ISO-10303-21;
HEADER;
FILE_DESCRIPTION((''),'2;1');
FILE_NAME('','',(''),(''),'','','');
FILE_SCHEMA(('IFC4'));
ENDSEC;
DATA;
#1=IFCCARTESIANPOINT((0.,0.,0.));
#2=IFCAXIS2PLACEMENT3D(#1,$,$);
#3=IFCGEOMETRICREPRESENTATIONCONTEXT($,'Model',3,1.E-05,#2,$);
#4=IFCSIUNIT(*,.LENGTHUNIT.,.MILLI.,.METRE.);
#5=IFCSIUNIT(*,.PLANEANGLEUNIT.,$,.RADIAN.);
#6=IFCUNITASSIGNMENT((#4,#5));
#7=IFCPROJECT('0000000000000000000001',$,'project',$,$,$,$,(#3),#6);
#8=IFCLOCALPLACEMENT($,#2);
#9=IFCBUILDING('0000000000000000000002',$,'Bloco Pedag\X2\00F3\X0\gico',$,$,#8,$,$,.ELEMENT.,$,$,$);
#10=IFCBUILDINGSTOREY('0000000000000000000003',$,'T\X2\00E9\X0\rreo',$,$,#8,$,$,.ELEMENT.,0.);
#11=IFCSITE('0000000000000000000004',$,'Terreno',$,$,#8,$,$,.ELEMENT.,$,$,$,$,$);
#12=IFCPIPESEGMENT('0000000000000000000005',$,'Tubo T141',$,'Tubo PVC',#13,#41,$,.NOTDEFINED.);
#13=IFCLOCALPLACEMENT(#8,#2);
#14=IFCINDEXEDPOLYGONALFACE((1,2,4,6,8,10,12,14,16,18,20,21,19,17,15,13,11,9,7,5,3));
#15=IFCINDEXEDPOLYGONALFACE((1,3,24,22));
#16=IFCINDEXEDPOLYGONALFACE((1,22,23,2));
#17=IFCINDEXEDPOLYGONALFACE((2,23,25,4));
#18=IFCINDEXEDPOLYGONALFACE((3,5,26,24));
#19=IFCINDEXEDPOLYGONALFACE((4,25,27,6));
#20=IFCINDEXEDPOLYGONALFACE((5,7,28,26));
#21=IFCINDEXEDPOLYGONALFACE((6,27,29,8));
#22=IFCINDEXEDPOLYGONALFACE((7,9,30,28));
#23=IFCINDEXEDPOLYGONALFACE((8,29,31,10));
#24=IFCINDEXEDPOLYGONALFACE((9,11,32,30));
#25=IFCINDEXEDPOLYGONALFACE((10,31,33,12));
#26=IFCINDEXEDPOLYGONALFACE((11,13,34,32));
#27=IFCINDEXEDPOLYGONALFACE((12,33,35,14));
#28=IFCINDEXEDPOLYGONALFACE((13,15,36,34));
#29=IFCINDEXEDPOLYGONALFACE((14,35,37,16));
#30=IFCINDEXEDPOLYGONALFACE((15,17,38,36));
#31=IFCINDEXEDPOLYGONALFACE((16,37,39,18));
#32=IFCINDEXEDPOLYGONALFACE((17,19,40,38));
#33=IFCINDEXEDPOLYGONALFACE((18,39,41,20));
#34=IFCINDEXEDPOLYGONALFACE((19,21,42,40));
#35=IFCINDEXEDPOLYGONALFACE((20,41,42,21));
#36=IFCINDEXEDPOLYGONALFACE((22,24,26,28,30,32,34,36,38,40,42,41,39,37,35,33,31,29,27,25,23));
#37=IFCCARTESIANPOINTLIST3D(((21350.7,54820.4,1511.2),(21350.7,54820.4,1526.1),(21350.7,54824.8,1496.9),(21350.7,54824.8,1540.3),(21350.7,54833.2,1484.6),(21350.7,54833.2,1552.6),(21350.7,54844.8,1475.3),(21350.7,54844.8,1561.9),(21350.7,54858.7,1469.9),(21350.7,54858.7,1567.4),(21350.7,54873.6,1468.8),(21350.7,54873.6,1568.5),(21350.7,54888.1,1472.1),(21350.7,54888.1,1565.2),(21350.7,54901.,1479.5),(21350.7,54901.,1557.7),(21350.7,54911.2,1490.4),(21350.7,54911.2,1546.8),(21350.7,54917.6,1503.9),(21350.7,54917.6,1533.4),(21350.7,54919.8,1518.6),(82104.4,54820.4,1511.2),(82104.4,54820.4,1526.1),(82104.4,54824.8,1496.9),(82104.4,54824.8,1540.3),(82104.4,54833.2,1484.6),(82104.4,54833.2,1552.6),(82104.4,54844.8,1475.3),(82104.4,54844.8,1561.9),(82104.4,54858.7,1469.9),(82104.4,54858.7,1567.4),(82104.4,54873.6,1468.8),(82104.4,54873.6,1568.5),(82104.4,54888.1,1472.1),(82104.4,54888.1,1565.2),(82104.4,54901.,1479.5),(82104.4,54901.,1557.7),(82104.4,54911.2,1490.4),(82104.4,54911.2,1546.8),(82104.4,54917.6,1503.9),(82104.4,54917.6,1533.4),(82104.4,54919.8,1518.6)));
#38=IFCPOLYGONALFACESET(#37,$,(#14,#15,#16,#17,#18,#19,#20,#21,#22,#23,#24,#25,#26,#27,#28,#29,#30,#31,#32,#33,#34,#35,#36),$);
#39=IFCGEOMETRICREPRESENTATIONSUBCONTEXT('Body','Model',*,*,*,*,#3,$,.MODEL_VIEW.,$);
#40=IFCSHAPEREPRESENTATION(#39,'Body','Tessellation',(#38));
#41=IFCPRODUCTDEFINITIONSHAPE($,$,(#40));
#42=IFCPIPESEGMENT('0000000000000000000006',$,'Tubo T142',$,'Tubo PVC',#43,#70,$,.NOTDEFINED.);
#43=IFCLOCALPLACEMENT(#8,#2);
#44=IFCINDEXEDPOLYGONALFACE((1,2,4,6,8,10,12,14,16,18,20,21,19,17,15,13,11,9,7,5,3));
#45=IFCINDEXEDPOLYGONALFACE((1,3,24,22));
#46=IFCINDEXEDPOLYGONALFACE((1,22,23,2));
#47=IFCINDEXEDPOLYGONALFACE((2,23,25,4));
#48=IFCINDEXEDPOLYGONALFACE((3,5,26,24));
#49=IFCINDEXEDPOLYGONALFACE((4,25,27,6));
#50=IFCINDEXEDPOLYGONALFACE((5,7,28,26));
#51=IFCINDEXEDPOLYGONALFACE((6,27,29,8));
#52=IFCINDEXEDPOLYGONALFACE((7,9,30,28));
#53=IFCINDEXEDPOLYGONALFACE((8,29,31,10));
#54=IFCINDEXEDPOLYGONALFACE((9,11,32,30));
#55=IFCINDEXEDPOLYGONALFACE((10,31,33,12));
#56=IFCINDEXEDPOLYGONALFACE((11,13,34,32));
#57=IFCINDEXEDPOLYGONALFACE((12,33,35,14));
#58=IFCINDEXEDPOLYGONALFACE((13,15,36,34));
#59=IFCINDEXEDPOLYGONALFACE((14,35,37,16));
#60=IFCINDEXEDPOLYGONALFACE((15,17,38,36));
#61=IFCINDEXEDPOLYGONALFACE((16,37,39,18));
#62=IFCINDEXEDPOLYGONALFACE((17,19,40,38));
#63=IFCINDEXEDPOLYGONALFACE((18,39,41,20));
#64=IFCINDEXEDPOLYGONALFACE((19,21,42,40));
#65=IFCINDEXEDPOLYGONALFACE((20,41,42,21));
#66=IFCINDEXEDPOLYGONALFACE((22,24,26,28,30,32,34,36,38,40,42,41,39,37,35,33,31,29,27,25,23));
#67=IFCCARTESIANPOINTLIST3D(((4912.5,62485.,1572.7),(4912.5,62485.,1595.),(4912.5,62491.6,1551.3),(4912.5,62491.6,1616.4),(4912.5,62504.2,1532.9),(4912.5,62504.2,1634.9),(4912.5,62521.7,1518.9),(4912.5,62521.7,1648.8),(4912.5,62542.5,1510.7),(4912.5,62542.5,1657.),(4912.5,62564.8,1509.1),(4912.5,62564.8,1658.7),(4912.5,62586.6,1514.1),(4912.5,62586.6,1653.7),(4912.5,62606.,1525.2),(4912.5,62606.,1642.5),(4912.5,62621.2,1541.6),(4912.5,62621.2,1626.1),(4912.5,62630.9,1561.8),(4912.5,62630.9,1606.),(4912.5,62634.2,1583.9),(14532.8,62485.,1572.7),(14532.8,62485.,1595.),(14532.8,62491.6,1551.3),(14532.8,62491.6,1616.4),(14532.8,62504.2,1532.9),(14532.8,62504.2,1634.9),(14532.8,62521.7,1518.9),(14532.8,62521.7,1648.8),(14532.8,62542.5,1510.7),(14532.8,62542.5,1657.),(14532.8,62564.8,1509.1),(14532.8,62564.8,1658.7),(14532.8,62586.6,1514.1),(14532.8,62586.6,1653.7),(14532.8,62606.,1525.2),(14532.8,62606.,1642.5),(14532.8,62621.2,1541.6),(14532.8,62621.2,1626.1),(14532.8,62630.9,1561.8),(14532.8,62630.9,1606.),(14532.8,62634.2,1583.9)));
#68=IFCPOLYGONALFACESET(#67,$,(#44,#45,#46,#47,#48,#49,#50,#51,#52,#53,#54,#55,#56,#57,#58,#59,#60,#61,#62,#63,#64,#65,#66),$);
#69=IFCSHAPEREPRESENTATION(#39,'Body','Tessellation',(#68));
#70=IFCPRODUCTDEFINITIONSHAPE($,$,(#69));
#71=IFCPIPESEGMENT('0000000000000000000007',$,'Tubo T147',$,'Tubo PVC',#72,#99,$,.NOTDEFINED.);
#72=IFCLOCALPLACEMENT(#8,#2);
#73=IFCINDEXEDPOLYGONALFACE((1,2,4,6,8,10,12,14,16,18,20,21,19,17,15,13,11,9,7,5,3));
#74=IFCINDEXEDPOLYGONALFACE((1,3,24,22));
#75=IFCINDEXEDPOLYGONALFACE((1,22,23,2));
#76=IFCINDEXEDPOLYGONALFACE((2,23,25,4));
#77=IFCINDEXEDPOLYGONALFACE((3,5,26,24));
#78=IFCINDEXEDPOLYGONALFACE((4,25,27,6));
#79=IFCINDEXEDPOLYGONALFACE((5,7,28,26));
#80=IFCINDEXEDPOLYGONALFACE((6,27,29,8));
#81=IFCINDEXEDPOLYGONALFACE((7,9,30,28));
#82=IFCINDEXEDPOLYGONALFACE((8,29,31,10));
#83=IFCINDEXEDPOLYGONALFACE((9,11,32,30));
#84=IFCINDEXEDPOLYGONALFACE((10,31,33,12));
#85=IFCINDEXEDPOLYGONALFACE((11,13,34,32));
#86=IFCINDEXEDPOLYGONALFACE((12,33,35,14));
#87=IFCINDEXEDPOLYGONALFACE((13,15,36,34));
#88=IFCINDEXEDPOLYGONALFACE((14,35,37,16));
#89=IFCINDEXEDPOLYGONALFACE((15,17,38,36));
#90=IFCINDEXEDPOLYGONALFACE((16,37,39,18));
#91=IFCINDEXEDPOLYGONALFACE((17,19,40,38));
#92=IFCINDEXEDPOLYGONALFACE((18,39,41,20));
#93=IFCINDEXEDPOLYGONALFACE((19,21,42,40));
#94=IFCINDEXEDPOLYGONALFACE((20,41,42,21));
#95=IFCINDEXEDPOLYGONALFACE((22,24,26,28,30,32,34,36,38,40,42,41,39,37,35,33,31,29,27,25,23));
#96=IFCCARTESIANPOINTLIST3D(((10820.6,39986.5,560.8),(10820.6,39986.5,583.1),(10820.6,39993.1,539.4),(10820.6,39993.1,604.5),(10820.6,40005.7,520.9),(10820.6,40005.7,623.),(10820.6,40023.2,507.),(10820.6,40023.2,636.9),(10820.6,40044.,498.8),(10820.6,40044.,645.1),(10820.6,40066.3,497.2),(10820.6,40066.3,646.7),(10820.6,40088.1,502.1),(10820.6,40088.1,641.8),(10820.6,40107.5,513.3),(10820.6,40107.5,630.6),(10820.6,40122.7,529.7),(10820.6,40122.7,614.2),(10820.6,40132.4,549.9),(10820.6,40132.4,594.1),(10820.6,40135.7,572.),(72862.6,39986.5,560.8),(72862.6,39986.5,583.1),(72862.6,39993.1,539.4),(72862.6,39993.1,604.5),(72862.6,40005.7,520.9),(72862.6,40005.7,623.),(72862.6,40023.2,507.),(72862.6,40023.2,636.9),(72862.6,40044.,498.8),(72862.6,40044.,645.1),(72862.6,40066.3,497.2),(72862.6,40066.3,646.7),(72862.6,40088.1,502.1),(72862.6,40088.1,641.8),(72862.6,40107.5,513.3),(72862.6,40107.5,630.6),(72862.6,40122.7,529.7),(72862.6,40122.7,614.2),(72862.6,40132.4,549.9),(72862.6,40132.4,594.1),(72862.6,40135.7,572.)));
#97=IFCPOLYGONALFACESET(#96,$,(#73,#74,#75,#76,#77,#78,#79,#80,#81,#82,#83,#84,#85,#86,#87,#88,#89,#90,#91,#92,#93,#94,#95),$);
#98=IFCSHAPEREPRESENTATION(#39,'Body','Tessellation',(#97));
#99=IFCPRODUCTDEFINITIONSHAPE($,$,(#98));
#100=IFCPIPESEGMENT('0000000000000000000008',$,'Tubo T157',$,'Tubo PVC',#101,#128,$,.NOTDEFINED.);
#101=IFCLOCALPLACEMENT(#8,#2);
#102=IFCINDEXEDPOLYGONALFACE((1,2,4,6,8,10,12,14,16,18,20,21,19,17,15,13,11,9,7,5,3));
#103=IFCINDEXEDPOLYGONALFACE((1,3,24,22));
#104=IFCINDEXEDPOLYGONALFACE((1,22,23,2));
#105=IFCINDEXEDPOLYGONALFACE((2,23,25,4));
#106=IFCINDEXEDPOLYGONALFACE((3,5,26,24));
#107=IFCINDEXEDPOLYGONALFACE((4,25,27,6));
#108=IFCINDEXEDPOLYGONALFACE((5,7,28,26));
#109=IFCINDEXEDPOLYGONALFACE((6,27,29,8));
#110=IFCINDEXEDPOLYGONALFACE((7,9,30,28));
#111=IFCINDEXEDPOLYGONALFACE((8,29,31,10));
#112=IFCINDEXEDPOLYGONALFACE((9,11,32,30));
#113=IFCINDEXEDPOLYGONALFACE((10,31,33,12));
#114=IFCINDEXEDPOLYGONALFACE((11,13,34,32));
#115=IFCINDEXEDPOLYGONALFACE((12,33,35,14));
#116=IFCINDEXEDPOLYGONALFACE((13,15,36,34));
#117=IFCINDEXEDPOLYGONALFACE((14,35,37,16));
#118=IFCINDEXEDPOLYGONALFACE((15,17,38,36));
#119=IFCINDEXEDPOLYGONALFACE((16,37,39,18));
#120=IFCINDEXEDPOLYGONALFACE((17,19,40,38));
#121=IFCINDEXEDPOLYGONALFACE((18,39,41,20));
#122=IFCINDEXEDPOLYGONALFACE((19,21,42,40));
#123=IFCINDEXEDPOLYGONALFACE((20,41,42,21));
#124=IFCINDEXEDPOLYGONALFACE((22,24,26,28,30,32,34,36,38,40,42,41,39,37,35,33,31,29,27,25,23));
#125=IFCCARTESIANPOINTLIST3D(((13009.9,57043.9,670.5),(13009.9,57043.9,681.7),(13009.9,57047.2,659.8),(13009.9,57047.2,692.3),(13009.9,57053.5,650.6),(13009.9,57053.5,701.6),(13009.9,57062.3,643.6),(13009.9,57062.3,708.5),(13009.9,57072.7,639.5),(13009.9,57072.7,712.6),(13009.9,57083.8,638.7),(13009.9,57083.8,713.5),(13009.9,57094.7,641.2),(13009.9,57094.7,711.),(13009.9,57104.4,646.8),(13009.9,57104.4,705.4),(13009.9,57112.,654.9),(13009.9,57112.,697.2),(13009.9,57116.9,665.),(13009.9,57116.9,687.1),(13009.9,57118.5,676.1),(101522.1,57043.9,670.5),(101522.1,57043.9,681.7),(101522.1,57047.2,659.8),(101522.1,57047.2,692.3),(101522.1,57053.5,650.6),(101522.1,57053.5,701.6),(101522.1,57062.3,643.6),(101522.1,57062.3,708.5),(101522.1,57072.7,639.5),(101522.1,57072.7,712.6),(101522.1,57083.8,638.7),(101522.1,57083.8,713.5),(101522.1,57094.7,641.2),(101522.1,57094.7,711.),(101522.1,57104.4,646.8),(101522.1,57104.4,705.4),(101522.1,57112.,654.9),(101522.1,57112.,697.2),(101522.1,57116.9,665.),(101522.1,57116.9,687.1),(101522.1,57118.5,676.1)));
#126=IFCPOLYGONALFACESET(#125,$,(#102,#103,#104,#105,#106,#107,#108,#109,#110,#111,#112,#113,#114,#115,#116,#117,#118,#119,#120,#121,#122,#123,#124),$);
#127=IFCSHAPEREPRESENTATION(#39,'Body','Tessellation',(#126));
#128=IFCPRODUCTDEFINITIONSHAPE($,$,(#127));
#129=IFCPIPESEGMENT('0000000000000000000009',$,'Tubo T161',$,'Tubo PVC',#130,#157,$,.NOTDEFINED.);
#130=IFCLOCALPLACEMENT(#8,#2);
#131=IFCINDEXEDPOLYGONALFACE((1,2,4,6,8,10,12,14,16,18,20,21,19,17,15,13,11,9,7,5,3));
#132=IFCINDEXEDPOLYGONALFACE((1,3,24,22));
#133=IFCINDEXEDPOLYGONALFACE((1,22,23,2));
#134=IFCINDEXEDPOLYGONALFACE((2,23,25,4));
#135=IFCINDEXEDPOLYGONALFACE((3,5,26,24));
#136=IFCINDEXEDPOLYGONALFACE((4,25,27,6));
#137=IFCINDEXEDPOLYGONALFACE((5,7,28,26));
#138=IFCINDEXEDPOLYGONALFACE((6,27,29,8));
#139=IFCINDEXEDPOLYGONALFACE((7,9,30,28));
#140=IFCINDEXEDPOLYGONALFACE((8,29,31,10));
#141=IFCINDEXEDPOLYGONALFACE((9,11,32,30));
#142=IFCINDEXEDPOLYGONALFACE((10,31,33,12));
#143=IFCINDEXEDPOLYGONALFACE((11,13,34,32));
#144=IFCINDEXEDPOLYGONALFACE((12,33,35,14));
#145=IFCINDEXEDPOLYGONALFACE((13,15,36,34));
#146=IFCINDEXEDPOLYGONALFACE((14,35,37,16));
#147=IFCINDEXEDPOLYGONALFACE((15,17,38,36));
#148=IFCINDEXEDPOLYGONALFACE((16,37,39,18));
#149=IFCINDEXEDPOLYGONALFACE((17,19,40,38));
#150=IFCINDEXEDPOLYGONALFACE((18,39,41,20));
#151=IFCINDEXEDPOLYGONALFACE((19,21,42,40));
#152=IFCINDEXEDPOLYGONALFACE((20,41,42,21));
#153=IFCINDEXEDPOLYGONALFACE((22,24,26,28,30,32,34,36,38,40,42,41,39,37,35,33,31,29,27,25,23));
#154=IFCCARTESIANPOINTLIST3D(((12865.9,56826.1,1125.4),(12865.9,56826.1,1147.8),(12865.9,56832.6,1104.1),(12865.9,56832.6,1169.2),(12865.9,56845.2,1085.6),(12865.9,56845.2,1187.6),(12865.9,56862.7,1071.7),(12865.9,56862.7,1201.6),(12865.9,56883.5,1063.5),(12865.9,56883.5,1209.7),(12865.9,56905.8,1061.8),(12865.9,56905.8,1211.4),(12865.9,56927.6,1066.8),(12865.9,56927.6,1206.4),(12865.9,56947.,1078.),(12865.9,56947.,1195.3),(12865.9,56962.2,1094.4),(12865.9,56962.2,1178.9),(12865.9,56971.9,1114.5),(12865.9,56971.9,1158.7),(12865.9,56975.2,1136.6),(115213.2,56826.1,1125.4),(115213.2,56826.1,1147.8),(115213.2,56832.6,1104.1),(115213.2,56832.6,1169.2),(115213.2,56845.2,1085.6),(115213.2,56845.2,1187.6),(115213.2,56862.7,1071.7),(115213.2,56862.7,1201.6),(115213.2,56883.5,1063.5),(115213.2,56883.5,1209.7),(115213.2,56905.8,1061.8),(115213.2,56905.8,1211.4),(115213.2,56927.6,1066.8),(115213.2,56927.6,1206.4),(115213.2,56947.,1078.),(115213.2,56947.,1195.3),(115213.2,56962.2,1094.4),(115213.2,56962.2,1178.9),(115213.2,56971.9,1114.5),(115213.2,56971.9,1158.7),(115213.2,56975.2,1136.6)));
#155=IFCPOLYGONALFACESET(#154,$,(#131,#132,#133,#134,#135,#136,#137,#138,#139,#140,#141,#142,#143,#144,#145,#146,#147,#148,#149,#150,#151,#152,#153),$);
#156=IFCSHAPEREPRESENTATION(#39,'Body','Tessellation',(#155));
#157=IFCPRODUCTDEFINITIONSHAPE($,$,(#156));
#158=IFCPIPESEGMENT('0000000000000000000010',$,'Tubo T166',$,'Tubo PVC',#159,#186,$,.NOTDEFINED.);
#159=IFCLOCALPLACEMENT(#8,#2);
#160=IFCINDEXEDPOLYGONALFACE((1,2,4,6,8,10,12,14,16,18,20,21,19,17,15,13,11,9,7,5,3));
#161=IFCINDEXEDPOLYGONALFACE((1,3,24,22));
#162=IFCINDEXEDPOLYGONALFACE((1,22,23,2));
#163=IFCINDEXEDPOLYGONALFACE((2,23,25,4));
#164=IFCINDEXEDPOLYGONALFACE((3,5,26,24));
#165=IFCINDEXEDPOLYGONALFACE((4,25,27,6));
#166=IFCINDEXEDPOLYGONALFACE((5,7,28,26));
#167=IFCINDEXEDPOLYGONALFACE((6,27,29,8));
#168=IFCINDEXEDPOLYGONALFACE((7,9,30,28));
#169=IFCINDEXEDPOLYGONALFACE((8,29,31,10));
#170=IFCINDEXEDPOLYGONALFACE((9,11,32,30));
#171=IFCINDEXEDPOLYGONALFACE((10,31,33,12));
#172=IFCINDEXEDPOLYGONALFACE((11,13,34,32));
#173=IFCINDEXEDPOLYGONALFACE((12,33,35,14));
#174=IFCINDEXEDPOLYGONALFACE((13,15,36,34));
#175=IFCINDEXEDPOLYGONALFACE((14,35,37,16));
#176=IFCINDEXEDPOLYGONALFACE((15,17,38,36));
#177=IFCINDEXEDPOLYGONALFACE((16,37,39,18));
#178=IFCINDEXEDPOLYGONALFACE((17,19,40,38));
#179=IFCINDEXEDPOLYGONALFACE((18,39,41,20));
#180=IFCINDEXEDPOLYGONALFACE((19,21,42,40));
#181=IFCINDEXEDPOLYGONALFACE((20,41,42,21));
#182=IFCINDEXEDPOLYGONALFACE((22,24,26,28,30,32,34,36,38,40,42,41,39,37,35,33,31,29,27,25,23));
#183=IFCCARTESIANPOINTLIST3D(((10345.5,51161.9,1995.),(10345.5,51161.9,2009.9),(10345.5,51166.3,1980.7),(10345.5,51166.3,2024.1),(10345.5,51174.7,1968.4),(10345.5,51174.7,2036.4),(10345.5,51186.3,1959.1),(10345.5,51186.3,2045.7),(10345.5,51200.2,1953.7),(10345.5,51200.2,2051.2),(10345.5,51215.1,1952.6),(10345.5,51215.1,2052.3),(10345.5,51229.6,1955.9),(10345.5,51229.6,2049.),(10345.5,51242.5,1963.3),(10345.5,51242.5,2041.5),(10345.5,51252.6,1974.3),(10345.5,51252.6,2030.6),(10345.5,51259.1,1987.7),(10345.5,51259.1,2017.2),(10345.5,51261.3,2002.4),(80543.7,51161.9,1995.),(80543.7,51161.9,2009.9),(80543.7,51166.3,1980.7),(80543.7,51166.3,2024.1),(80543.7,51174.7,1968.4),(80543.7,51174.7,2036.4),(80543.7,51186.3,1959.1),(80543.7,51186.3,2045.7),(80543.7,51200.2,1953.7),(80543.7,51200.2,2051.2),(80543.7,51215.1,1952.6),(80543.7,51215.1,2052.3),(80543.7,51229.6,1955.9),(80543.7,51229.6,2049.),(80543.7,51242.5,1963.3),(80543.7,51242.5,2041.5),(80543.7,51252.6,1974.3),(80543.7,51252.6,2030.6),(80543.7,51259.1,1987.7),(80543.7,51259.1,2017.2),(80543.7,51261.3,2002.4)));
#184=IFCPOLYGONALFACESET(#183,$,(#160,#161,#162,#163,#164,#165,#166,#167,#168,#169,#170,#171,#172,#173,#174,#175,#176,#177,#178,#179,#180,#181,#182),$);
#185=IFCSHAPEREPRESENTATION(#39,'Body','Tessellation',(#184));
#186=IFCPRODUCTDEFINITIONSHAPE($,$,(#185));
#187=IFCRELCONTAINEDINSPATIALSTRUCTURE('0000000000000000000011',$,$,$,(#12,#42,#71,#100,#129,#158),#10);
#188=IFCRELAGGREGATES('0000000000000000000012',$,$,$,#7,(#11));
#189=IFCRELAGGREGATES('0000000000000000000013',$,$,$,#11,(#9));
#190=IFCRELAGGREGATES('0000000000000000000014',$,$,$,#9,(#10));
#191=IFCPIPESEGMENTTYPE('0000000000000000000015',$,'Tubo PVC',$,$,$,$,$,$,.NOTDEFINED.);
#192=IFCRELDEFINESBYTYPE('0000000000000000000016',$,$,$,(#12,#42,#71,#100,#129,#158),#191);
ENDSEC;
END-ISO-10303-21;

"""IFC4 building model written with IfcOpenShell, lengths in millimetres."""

from ifc_helpers import new_model, si_unit, frame, origin, origin_2d, place, context, subcontext, project, spatial, circle, extrude, type_object, element, save


model = new_model("IFC4")

# Units and contexts
model_context = context("Model", 3, precision=1e-05, world=origin())
body_context = subcontext(model_context, "Body", "Model", "MODEL_VIEW")
ifc_project = project(units=[si_unit("LENGTHUNIT", "METRE", prefix="MILLI"), si_unit("PLANEANGLEUNIT", "RADIAN")], contexts=[model_context])

# Site, building, storey
placement = place(None, origin())
site = spatial("IfcSite", under=ifc_project, at=placement, Name="Terreno", CompositionType="ELEMENT")
building = spatial("IfcBuilding", under=site, at=placement, Name="Bloco Pedagógico", CompositionType="ELEMENT")
storey = spatial("IfcBuildingStorey", under=building, at=placement, Name="Térreo", CompositionType="ELEMENT", Elevation=0.0)

# Pipe segments
pipe_segment_type = type_object("IfcPipeSegmentType", Name="Tubo PVC", PredefinedType="NOTDEFINED")
pipe_segment_1_placement = place(None, frame((21350.7, 54869.8, 1518.6), z_axis=(1.0, 0.0, 0.0), x_axis=(0.0, 1.0, 0.0)))
element("IfcPipeSegment", 1, at=pipe_segment_1_placement, inside=storey, type_object=pipe_segment_type, Name="Tubo T141", ObjectType="Tubo PVC", PredefinedType="NOTDEFINED", context=body_context, shape_type="SweptSolid", body=[
    extrude(circle(Radius=50.0, at=origin_2d()), None, (0.0, 0.0, 1.0), 60753.7),
])
pipe_segment_2_placement = place(None, frame((4912.5, 62559.2, 1583.9), z_axis=(1.0, 0.0, 0.0), x_axis=(0.0, 1.0, 0.0)))
element("IfcPipeSegment", 2, at=pipe_segment_2_placement, inside=storey, type_object=pipe_segment_type, Name="Tubo T142", ObjectType="Tubo PVC", PredefinedType="NOTDEFINED", context=body_context, shape_type="SweptSolid", body=[
    extrude(circle(Radius=75.0, at=origin_2d()), None, (0.0, 0.0, 1.0), 9620.4),
])
pipe_segment_3_placement = place(None, frame((10820.6, 40060.7, 572.0), z_axis=(1.0, 0.0, 0.0), x_axis=(0.0, 1.0, 0.0)))
element("IfcPipeSegment", 3, at=pipe_segment_3_placement, inside=storey, type_object=pipe_segment_type, Name="Tubo T147", ObjectType="Tubo PVC", PredefinedType="NOTDEFINED", context=body_context, shape_type="SweptSolid", body=[
    extrude(circle(Radius=75.0, at=origin_2d()), None, (0.0, 0.0, 1.0), 62042.0),
])
pipe_segment_4_placement = place(None, frame((13009.9, 57081.0, 676.1), z_axis=(1.0, 0.0, 0.0), x_axis=(0.0, 1.0, 0.0)))
element("IfcPipeSegment", 4, at=pipe_segment_4_placement, inside=storey, type_object=pipe_segment_type, Name="Tubo T157", ObjectType="Tubo PVC", PredefinedType="NOTDEFINED", context=body_context, shape_type="SweptSolid", body=[
    extrude(circle(Radius=37.5, at=origin_2d()), None, (0.0, 0.0, 1.0), 88512.2),
])
pipe_segment_5_placement = place(None, frame((12865.9, 56900.2, 1136.6), z_axis=(1.0, 0.0, 0.0), x_axis=(0.0, 1.0, 0.0)))
element("IfcPipeSegment", 5, at=pipe_segment_5_placement, inside=storey, type_object=pipe_segment_type, Name="Tubo T161", ObjectType="Tubo PVC", PredefinedType="NOTDEFINED", context=body_context, shape_type="SweptSolid", body=[
    extrude(circle(Radius=75.0, at=origin_2d()), None, (0.0, 0.0, 1.0), 102347.3),
])
pipe_segment_6_placement = place(None, frame((10345.5, 51211.3, 2002.4), z_axis=(1.0, 0.0, 0.0), x_axis=(0.0, 1.0, 0.0)))
element("IfcPipeSegment", 6, at=pipe_segment_6_placement, inside=storey, type_object=pipe_segment_type, Name="Tubo T166", ObjectType="Tubo PVC", PredefinedType="NOTDEFINED", context=body_context, shape_type="SweptSolid", body=[
    extrude(circle(Radius=50.0, at=origin_2d()), None, (0.0, 0.0, 1.0), 70198.2),
])

save(model, "model.ifc")
